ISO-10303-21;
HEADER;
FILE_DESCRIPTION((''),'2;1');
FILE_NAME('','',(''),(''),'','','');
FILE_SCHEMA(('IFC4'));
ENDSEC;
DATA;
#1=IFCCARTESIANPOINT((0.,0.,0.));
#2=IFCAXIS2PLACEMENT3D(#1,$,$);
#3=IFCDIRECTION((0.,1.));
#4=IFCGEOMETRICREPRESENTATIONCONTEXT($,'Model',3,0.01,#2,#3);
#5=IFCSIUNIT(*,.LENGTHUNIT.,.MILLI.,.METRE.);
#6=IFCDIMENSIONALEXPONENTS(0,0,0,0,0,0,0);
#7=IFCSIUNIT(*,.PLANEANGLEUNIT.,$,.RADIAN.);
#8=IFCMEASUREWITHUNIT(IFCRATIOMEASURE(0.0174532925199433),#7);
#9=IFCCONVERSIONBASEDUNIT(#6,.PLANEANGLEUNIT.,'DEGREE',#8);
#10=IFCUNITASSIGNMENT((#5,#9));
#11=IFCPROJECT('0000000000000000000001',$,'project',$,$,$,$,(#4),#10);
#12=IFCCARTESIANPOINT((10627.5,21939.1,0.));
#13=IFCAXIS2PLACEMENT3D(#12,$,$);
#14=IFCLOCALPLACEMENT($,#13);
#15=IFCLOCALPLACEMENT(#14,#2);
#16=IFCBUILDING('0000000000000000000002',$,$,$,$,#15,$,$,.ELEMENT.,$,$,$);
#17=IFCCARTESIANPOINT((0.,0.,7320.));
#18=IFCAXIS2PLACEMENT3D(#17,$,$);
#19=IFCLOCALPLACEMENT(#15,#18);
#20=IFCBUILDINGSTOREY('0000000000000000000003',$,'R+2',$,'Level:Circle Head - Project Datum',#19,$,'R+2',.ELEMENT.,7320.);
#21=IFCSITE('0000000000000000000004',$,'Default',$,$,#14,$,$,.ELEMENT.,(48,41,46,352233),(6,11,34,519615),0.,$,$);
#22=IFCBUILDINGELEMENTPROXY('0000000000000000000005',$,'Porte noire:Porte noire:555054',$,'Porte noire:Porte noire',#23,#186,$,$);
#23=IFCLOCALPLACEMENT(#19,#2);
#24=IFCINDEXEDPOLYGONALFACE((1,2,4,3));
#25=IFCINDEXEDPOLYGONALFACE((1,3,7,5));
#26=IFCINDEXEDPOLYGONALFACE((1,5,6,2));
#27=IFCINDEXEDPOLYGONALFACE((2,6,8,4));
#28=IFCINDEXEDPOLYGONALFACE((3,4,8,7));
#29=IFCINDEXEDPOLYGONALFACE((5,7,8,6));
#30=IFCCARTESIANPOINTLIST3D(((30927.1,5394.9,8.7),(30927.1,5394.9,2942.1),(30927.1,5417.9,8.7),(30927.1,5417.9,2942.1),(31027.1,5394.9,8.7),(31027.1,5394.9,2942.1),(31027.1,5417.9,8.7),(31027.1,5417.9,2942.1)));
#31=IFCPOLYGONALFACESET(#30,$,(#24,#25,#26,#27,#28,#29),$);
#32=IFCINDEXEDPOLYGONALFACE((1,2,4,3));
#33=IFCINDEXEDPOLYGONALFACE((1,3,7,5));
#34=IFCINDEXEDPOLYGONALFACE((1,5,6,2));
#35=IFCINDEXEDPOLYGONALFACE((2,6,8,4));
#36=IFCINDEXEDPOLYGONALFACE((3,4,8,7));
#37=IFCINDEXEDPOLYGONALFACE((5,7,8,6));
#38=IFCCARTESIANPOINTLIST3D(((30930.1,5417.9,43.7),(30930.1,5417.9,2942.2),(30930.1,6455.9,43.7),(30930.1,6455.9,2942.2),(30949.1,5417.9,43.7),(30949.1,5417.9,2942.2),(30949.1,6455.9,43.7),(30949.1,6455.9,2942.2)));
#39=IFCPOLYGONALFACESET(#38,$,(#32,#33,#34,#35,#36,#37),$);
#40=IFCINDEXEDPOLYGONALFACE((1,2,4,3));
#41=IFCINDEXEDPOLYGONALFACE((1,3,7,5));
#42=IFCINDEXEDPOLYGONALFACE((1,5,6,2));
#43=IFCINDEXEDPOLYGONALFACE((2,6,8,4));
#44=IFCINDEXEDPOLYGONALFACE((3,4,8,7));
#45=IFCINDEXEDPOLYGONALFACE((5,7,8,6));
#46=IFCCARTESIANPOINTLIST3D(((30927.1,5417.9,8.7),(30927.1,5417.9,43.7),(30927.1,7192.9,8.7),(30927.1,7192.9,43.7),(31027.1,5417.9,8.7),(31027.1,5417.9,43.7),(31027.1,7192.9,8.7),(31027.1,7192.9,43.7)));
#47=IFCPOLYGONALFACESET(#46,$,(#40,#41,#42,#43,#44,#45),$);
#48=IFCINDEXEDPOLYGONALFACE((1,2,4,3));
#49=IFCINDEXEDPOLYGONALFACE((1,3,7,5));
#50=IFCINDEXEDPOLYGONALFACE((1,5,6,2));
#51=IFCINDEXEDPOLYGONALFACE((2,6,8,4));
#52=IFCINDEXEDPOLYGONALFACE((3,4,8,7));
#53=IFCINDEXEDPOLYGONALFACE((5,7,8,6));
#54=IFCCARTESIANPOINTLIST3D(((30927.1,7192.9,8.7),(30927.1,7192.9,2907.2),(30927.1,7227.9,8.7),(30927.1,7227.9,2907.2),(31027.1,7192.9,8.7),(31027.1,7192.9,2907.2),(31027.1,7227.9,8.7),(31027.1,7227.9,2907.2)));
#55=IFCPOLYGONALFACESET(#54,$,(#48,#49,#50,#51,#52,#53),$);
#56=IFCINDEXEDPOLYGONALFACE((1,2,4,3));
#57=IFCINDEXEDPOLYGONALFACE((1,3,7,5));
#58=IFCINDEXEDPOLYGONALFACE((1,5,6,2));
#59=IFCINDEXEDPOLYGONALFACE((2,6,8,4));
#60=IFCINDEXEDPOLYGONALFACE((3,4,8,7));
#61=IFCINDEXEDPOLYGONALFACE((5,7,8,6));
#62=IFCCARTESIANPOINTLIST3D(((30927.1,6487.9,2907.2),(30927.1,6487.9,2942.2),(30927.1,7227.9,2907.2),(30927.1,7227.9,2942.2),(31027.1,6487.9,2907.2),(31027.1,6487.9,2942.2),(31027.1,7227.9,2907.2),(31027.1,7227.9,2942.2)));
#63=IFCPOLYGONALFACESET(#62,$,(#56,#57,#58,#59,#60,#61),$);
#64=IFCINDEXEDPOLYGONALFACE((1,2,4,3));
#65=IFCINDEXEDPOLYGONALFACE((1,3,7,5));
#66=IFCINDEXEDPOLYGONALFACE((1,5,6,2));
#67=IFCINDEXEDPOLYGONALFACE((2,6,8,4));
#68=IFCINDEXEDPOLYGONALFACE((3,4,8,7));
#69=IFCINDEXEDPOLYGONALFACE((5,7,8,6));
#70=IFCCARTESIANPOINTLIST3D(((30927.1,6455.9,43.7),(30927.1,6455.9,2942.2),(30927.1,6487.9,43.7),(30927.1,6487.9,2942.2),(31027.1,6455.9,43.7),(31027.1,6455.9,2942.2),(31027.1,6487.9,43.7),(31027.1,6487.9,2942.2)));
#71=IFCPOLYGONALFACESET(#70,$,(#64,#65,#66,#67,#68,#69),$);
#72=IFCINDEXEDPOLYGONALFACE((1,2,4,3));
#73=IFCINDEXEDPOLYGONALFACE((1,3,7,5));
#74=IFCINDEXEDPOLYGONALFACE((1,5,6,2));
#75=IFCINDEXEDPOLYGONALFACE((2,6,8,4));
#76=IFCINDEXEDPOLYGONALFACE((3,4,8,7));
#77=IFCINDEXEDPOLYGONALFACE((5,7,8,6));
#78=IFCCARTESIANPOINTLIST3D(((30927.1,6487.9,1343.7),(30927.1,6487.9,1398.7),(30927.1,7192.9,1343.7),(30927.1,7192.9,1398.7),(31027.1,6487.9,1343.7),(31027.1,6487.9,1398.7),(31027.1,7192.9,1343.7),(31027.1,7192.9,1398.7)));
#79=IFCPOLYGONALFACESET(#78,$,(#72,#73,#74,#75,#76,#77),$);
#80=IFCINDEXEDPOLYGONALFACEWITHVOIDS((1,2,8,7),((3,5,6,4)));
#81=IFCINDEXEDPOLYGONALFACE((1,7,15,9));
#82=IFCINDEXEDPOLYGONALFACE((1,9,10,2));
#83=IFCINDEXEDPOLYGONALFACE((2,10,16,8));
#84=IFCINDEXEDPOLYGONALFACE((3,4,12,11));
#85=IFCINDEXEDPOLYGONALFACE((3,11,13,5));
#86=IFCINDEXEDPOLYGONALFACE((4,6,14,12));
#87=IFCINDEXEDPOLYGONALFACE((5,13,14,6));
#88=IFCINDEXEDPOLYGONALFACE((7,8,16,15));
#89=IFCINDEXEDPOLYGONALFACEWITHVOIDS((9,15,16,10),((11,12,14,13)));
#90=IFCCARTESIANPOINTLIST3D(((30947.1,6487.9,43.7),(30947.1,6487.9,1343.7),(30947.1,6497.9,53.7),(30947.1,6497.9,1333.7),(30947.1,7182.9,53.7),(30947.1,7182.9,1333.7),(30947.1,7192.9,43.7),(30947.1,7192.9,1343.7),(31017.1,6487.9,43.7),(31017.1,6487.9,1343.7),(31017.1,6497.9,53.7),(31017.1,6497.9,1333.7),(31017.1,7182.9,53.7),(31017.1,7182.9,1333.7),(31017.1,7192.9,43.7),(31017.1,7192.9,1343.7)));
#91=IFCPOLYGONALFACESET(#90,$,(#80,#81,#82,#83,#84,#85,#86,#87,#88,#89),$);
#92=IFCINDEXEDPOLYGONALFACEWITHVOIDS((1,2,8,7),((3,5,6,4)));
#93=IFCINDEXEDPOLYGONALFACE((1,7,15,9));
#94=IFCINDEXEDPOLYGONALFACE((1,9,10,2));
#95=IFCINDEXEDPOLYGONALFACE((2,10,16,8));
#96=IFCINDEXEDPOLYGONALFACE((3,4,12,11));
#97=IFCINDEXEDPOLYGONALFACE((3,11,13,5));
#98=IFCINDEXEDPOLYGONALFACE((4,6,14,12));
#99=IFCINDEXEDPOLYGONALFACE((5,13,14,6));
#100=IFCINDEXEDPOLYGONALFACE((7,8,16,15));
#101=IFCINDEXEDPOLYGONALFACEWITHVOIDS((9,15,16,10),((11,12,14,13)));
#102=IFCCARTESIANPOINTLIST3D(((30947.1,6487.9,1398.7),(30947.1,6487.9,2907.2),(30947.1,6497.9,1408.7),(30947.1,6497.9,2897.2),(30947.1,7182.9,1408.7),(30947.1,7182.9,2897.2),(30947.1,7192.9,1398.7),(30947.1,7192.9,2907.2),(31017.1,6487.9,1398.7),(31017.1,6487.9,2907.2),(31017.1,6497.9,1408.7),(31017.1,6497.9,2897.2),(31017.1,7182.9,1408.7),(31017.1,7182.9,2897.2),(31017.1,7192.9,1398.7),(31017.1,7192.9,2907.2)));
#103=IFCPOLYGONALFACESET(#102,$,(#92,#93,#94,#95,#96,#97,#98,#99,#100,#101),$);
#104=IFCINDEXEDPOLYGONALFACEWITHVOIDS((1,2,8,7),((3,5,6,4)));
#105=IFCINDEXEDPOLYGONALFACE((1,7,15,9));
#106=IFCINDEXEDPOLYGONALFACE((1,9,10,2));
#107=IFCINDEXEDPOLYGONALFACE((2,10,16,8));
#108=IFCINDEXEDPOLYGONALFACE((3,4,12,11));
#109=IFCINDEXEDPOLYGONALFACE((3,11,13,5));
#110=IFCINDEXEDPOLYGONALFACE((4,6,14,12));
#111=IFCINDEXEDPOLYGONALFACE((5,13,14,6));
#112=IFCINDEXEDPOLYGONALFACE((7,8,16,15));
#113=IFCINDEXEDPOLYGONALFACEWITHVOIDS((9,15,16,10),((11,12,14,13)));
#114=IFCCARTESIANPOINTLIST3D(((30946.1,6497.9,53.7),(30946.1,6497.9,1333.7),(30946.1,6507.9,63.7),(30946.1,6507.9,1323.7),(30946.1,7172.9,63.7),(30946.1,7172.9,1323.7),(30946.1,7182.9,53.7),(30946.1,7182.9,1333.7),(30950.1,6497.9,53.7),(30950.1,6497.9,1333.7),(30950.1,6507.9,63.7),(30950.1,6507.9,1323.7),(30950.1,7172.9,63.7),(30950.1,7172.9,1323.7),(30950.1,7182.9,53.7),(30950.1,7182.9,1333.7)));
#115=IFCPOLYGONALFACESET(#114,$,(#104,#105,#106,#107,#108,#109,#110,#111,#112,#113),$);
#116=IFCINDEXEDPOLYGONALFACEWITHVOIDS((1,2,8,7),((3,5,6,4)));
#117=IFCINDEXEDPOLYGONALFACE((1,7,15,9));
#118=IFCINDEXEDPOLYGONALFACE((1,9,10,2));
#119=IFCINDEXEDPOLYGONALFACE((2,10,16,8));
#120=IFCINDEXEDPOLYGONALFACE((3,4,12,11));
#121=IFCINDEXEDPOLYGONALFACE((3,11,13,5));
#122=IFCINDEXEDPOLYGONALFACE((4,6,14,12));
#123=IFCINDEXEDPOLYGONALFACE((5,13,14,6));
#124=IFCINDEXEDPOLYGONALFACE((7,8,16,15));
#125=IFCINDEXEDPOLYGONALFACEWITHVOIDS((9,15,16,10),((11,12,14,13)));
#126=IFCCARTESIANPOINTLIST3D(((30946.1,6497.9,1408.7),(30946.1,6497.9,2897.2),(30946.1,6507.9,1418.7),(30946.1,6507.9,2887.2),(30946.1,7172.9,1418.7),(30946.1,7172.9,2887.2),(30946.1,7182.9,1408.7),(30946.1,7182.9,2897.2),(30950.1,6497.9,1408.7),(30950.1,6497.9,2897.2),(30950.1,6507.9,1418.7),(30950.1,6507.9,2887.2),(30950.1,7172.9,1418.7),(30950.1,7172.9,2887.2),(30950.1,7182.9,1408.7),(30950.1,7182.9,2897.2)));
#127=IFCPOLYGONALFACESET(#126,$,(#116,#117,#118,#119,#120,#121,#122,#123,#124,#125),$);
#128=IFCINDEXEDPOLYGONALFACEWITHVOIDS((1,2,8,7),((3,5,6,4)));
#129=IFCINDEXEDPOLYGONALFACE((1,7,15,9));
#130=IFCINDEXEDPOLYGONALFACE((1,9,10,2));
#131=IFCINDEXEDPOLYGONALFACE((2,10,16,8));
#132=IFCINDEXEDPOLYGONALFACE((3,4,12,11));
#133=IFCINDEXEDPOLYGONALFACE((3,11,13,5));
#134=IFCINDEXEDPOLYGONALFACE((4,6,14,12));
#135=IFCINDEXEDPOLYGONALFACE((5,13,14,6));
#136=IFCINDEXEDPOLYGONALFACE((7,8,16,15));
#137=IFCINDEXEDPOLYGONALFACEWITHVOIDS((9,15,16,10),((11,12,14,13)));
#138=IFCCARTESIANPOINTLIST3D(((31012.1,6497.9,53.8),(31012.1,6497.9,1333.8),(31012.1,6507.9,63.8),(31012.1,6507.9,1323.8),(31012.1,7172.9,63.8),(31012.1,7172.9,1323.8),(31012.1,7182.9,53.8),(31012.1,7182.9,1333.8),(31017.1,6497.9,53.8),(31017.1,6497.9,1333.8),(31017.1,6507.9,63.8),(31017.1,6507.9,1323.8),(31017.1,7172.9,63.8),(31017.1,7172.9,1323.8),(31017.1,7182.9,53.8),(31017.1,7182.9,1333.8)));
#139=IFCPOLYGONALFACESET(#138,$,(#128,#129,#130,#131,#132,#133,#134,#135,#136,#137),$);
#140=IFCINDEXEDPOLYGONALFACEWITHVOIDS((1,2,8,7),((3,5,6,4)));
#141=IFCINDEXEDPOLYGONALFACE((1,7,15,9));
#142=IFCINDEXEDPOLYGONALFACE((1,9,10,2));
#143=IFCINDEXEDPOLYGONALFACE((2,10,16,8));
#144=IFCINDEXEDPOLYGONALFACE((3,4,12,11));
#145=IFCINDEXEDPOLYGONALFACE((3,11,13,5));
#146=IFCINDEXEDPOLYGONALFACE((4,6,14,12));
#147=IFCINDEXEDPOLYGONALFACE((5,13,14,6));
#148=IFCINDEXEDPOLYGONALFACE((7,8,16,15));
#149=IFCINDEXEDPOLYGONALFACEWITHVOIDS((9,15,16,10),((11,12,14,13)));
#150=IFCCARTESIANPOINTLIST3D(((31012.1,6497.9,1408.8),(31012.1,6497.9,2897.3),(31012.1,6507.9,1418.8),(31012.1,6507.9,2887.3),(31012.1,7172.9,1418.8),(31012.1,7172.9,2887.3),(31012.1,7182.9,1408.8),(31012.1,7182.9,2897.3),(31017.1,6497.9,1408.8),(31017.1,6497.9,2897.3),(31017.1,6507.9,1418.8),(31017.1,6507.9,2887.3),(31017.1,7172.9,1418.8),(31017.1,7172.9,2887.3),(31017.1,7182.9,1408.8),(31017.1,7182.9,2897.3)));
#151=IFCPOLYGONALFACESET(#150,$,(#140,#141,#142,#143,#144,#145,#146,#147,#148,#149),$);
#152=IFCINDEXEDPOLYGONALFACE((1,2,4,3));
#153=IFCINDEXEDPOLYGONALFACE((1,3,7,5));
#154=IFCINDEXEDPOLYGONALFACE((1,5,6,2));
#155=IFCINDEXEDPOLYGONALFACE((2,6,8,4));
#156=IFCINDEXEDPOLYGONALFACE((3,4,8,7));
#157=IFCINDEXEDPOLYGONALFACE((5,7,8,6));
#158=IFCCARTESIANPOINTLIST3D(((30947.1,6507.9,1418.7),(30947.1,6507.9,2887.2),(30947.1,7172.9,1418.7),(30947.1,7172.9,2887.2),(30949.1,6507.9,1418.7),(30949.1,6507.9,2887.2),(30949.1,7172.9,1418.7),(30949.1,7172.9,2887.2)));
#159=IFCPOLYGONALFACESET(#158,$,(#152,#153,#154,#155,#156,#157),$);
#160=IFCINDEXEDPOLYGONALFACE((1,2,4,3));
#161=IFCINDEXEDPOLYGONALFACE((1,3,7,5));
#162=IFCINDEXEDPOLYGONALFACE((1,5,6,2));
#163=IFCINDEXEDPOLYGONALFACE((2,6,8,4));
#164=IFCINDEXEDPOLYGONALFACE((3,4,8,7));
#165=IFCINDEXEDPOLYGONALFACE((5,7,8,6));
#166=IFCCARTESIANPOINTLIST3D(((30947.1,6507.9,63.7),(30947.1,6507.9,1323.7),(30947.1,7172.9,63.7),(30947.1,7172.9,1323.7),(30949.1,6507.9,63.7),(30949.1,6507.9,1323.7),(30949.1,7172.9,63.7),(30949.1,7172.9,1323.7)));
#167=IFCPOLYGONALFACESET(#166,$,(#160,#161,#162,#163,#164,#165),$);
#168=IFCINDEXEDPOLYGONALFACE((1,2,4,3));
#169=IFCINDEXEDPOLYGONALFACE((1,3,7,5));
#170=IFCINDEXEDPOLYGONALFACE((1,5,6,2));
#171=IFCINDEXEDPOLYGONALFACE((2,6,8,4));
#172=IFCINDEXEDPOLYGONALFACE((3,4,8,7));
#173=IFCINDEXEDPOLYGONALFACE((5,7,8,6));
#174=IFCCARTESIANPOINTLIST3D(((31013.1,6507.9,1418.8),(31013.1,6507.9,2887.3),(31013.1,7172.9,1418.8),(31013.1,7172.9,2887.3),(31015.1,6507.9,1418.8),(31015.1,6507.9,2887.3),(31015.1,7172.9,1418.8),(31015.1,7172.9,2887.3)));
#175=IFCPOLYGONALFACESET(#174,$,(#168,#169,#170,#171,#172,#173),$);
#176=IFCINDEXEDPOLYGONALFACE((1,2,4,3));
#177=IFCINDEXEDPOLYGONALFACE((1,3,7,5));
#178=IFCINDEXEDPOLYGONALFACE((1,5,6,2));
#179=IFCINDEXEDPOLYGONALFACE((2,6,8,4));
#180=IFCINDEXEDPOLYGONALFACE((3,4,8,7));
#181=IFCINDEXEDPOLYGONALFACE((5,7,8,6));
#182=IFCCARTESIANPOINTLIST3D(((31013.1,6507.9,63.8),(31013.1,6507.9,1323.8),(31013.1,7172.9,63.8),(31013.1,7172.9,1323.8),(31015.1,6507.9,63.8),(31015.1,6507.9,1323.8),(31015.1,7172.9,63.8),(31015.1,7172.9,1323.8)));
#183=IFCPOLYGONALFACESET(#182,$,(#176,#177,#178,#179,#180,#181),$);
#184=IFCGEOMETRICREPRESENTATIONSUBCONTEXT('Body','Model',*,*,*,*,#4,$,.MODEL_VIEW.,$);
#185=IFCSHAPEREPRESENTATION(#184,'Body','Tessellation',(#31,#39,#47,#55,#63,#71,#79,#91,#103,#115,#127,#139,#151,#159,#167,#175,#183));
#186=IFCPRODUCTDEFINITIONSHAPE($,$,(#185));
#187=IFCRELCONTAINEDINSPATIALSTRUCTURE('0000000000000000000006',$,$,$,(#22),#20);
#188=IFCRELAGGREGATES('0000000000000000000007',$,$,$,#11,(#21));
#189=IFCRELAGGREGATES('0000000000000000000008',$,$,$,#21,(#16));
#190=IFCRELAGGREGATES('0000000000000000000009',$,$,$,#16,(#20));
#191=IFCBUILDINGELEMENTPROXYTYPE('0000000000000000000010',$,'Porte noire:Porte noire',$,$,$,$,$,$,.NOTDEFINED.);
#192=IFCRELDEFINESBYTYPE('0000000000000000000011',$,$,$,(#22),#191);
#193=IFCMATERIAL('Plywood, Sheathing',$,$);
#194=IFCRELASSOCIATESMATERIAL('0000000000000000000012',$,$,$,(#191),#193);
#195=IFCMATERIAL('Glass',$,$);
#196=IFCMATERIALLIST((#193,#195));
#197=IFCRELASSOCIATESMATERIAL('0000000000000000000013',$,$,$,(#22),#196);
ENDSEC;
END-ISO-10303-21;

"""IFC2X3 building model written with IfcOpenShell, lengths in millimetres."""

from ifc_helpers import new_model, entity, si_unit, converted_unit, direction, frame, frame_2d, origin, origin_2d_with_axis, place, context, subcontext, project, spatial, polyline, rectangle, outline, extrude, source, transform, mapped, material, material_list, type_object, type_shapes, element, save


model = new_model("IFC2X3")

# Units and contexts
model_context = context("Model", 3, precision=0.01, world=origin(), true_north=direction((0.0, 1.0)))
body_context = subcontext(model_context, "Body", "Model", "MODEL_VIEW")
ifc_project = project(units=[si_unit("LENGTHUNIT", "METRE", prefix="MILLI"), converted_unit("PLANEANGLEUNIT", "DEGREE", entity("IfcRatioMeasure", 0.0174532925199433), si_unit("PLANEANGLEUNIT", "RADIAN"), dimensions=[0, 0, 0, 0, 0, 0, 0])], contexts=[model_context])

# Site, building, storey
site_placement = place(None, frame((10627.5, 21939.1, 0.0)))
site = spatial("IfcSite", under=ifc_project, at=site_placement, Name="Default", CompositionType="ELEMENT", RefLatitude=(48, 41, 46, 352233), RefLongitude=(6, 11, 34, 519615), RefElevation=0.0)
building_placement = place(site_placement, origin())
building = spatial("IfcBuilding", under=site, at=building_placement, CompositionType="ELEMENT")
storey_placement = place(building_placement, frame((0.0, 0.0, 7320.0)))
storey = spatial("IfcBuildingStorey", under=building, at=storey_placement, Name="R+2", ObjectType="Level:Circle Head - Project Datum", LongName="R+2", CompositionType="ELEMENT", Elevation=7320.0)

# Building element proxy
ifc_material_1 = material(Name="Glass")
ifc_material_2 = material(Name="Plywood, Sheathing")
building_element_proxy_type_1 = type_object("IfcBuildingElementProxyType", Name="Porte noire:Porte noire", PredefinedType="NOTDEFINED", material=ifc_material_2)
shared_shape_1 = source(origin(), body_context, "Body", "SweptSolid", [
    extrude(rectangle(XDim=23.0, YDim=100.0, at=frame_2d((0.0, 0.0), x_axis=(1.0, 0.0))), frame((-950.9, 50.0, 8.7), z_axis=(0.0, 0.0, 1.0), x_axis=(-1.0, 0.0, 0.0)), (0.0, 0.0, 1.0), 2933.3),
    extrude(rectangle(XDim=1038.0, YDim=19.0, at=frame_2d((0.0, 0.0), x_axis=(1.0, 0.0))), frame((-420.4, 87.5, 43.7), z_axis=(0.0, 0.0, 1.0), x_axis=(-1.0, 0.0, 0.0)), (0.0, 0.0, 1.0), 2898.5),
    extrude(rectangle(XDim=1775.0, YDim=100.0, at=origin_2d_with_axis()), frame((-51.9, 50.0, 8.7), z_axis=(0.0, 0.0, 1.0), x_axis=(-1.0, 0.0, 0.0)), (0.0, 0.0, 1.0), 35.0),
    extrude(rectangle(XDim=35.0, YDim=100.0, at=origin_2d_with_axis()), frame((853.1, 50.0, 8.7), z_axis=(0.0, 0.0, 1.0), x_axis=(-1.0, 0.0, 0.0)), (0.0, 0.0, 1.0), 2898.5),
    extrude(rectangle(XDim=740.0, YDim=100.0, at=origin_2d_with_axis()), frame((500.6, 50.0, 2907.2), z_axis=(0.0, 0.0, 1.0), x_axis=(-1.0, 0.0, 0.0)), (0.0, 0.0, 1.0), 35.0),
    extrude(rectangle(XDim=32.0, YDim=100.0, at=origin_2d_with_axis()), frame((114.6, 50.0, 43.7), z_axis=(0.0, 0.0, 1.0), x_axis=(-1.0, 0.0, 0.0)), (0.0, 0.0, 1.0), 2898.5),
    extrude(rectangle(XDim=705.0, YDim=100.0, at=origin_2d_with_axis()), frame((483.1, 50.0, 1343.7), z_axis=(0.0, 0.0, 1.0), x_axis=(-1.0, 0.0, 0.0)), (0.0, 0.0, 1.0), 55.0),
    extrude(outline(polyline([(-352.5, -650.0), (352.5, -650.0), (352.5, 650.0), (-352.5, 650.0), (-352.5, -650.0)]), holes=[polyline([(342.5, 640.0), (342.5, -640.0), (-342.5, -640.0), (-342.5, 640.0), (342.5, 640.0)])]), frame((483.1, 10.0, 693.7), z_axis=(0.0, 1.0, 0.0), x_axis=(1.0, 0.0, 0.0)), (0.0, 0.0, 1.0), 70.0),
    extrude(outline(polyline([(-754.2, -352.5), (754.2, -352.5), (754.2, 352.5), (-754.2, 352.5), (-754.2, -352.5)]), holes=[polyline([(744.2, 342.5), (744.2, -342.5), (-744.2, -342.5), (-744.2, 342.5), (744.2, 342.5)])]), frame((483.1, 10.0, 2153.0), z_axis=(0.0, 1.0, 0.0), x_axis=(0.0, 0.0, 1.0)), (0.0, 0.0, 1.0), 70.0),
    extrude(outline(polyline([(-640.0, -342.5), (640.0, -342.5), (640.0, 342.5), (-640.0, 342.5), (-640.0, -342.5)]), holes=[polyline([(630.0, 332.5), (630.0, -332.5), (-630.0, -332.5), (-630.0, 332.5), (630.0, 332.5)])]), frame((483.1, 77.0, 693.7), z_axis=(0.0, 1.0, 0.0), x_axis=(0.0, 0.0, 1.0)), (0.0, 0.0, 1.0), 4.0),
    extrude(outline(polyline([(-744.2, -342.5), (744.2, -342.5), (744.2, 342.5), (-744.2, 342.5), (-744.2, -342.5)]), holes=[polyline([(734.2, 332.5), (734.2, -332.5), (-734.2, -332.5), (-734.2, 332.5), (734.2, 332.5)])]), frame((483.1, 77.0, 2153.0), z_axis=(0.0, 1.0, 0.0), x_axis=(0.0, 0.0, 1.0)), (0.0, 0.0, 1.0), 4.0),
    extrude(outline(polyline([(-640.0, -342.5), (640.0, -342.5), (640.0, 342.5), (-640.0, 342.5), (-640.0, -342.5)]), holes=[polyline([(630.0, 332.5), (630.0, -332.5), (-630.0, -332.5), (-630.0, 332.5), (630.0, 332.5)])]), frame((483.1, 10.0, 693.8), z_axis=(0.0, 1.0, 0.0), x_axis=(0.0, 0.0, 1.0)), (0.0, 0.0, 1.0), 5.0),
    extrude(outline(polyline([(-744.2, -342.5), (744.2, -342.5), (744.2, 342.5), (-744.2, 342.5), (-744.2, -342.5)]), holes=[polyline([(734.2, 332.5), (734.2, -332.5), (-734.2, -332.5), (-734.2, 332.5), (734.2, 332.5)])]), frame((483.1, 10.0, 2153.0), z_axis=(0.0, 1.0, 0.0), x_axis=(0.0, 0.0, 1.0)), (0.0, 0.0, 1.0), 5.0),
    extrude(rectangle(XDim=665.0, YDim=2.0, at=frame_2d((0.0, 0.0), x_axis=(1.0, 0.0))), frame((483.1, 79.0, 1418.7), z_axis=(0.0, 0.0, 1.0), x_axis=(-1.0, 0.0, 0.0)), (0.0, 0.0, 1.0), 1468.5),
    extrude(rectangle(XDim=665.0, YDim=2.0, at=frame_2d((0.0, 0.0), x_axis=(1.0, 0.0))), frame((483.1, 79.0, 63.7), z_axis=(0.0, 0.0, 1.0), x_axis=(-1.0, 0.0, 0.0)), (0.0, 0.0, 1.0), 1260.0),
    extrude(rectangle(XDim=665.0, YDim=2.0, at=frame_2d((0.0, 0.0), x_axis=(1.0, 0.0))), frame((483.1, 13.0, 1418.8), z_axis=(0.0, 0.0, 1.0), x_axis=(-1.0, 0.0, 0.0)), (0.0, 0.0, 1.0), 1468.5),
    extrude(rectangle(XDim=665.0, YDim=2.0, at=frame_2d((0.0, 0.0), x_axis=(1.0, 0.0))), frame((483.1, 13.0, 63.8), z_axis=(0.0, 0.0, 1.0), x_axis=(-1.0, 0.0, 0.0)), (0.0, 0.0, 1.0), 1260.0),
])
type_shapes(building_element_proxy_type_1, [shared_shape_1])
ifc_material_list_1 = material_list([ifc_material_2, ifc_material_1])
proxy_1_placement = place(storey_placement, frame((31027.1, 6357.3, 0.0), z_axis=(0.0, 0.0, 1.0), x_axis=(0.0, 1.0, 0.0)))
element("IfcBuildingElementProxy", 1, at=proxy_1_placement, inside=storey, type_object=building_element_proxy_type_1, material=ifc_material_list_1, Name="Porte noire:Porte noire:555054", ObjectType="Porte noire:Porte noire", context=body_context, shape_type="MappedRepresentation", body=[
    mapped(shared_shape_1, transform((0.0, 0.0, 0.0), scale=1.0)),
])

save(model, "model.ifc")
